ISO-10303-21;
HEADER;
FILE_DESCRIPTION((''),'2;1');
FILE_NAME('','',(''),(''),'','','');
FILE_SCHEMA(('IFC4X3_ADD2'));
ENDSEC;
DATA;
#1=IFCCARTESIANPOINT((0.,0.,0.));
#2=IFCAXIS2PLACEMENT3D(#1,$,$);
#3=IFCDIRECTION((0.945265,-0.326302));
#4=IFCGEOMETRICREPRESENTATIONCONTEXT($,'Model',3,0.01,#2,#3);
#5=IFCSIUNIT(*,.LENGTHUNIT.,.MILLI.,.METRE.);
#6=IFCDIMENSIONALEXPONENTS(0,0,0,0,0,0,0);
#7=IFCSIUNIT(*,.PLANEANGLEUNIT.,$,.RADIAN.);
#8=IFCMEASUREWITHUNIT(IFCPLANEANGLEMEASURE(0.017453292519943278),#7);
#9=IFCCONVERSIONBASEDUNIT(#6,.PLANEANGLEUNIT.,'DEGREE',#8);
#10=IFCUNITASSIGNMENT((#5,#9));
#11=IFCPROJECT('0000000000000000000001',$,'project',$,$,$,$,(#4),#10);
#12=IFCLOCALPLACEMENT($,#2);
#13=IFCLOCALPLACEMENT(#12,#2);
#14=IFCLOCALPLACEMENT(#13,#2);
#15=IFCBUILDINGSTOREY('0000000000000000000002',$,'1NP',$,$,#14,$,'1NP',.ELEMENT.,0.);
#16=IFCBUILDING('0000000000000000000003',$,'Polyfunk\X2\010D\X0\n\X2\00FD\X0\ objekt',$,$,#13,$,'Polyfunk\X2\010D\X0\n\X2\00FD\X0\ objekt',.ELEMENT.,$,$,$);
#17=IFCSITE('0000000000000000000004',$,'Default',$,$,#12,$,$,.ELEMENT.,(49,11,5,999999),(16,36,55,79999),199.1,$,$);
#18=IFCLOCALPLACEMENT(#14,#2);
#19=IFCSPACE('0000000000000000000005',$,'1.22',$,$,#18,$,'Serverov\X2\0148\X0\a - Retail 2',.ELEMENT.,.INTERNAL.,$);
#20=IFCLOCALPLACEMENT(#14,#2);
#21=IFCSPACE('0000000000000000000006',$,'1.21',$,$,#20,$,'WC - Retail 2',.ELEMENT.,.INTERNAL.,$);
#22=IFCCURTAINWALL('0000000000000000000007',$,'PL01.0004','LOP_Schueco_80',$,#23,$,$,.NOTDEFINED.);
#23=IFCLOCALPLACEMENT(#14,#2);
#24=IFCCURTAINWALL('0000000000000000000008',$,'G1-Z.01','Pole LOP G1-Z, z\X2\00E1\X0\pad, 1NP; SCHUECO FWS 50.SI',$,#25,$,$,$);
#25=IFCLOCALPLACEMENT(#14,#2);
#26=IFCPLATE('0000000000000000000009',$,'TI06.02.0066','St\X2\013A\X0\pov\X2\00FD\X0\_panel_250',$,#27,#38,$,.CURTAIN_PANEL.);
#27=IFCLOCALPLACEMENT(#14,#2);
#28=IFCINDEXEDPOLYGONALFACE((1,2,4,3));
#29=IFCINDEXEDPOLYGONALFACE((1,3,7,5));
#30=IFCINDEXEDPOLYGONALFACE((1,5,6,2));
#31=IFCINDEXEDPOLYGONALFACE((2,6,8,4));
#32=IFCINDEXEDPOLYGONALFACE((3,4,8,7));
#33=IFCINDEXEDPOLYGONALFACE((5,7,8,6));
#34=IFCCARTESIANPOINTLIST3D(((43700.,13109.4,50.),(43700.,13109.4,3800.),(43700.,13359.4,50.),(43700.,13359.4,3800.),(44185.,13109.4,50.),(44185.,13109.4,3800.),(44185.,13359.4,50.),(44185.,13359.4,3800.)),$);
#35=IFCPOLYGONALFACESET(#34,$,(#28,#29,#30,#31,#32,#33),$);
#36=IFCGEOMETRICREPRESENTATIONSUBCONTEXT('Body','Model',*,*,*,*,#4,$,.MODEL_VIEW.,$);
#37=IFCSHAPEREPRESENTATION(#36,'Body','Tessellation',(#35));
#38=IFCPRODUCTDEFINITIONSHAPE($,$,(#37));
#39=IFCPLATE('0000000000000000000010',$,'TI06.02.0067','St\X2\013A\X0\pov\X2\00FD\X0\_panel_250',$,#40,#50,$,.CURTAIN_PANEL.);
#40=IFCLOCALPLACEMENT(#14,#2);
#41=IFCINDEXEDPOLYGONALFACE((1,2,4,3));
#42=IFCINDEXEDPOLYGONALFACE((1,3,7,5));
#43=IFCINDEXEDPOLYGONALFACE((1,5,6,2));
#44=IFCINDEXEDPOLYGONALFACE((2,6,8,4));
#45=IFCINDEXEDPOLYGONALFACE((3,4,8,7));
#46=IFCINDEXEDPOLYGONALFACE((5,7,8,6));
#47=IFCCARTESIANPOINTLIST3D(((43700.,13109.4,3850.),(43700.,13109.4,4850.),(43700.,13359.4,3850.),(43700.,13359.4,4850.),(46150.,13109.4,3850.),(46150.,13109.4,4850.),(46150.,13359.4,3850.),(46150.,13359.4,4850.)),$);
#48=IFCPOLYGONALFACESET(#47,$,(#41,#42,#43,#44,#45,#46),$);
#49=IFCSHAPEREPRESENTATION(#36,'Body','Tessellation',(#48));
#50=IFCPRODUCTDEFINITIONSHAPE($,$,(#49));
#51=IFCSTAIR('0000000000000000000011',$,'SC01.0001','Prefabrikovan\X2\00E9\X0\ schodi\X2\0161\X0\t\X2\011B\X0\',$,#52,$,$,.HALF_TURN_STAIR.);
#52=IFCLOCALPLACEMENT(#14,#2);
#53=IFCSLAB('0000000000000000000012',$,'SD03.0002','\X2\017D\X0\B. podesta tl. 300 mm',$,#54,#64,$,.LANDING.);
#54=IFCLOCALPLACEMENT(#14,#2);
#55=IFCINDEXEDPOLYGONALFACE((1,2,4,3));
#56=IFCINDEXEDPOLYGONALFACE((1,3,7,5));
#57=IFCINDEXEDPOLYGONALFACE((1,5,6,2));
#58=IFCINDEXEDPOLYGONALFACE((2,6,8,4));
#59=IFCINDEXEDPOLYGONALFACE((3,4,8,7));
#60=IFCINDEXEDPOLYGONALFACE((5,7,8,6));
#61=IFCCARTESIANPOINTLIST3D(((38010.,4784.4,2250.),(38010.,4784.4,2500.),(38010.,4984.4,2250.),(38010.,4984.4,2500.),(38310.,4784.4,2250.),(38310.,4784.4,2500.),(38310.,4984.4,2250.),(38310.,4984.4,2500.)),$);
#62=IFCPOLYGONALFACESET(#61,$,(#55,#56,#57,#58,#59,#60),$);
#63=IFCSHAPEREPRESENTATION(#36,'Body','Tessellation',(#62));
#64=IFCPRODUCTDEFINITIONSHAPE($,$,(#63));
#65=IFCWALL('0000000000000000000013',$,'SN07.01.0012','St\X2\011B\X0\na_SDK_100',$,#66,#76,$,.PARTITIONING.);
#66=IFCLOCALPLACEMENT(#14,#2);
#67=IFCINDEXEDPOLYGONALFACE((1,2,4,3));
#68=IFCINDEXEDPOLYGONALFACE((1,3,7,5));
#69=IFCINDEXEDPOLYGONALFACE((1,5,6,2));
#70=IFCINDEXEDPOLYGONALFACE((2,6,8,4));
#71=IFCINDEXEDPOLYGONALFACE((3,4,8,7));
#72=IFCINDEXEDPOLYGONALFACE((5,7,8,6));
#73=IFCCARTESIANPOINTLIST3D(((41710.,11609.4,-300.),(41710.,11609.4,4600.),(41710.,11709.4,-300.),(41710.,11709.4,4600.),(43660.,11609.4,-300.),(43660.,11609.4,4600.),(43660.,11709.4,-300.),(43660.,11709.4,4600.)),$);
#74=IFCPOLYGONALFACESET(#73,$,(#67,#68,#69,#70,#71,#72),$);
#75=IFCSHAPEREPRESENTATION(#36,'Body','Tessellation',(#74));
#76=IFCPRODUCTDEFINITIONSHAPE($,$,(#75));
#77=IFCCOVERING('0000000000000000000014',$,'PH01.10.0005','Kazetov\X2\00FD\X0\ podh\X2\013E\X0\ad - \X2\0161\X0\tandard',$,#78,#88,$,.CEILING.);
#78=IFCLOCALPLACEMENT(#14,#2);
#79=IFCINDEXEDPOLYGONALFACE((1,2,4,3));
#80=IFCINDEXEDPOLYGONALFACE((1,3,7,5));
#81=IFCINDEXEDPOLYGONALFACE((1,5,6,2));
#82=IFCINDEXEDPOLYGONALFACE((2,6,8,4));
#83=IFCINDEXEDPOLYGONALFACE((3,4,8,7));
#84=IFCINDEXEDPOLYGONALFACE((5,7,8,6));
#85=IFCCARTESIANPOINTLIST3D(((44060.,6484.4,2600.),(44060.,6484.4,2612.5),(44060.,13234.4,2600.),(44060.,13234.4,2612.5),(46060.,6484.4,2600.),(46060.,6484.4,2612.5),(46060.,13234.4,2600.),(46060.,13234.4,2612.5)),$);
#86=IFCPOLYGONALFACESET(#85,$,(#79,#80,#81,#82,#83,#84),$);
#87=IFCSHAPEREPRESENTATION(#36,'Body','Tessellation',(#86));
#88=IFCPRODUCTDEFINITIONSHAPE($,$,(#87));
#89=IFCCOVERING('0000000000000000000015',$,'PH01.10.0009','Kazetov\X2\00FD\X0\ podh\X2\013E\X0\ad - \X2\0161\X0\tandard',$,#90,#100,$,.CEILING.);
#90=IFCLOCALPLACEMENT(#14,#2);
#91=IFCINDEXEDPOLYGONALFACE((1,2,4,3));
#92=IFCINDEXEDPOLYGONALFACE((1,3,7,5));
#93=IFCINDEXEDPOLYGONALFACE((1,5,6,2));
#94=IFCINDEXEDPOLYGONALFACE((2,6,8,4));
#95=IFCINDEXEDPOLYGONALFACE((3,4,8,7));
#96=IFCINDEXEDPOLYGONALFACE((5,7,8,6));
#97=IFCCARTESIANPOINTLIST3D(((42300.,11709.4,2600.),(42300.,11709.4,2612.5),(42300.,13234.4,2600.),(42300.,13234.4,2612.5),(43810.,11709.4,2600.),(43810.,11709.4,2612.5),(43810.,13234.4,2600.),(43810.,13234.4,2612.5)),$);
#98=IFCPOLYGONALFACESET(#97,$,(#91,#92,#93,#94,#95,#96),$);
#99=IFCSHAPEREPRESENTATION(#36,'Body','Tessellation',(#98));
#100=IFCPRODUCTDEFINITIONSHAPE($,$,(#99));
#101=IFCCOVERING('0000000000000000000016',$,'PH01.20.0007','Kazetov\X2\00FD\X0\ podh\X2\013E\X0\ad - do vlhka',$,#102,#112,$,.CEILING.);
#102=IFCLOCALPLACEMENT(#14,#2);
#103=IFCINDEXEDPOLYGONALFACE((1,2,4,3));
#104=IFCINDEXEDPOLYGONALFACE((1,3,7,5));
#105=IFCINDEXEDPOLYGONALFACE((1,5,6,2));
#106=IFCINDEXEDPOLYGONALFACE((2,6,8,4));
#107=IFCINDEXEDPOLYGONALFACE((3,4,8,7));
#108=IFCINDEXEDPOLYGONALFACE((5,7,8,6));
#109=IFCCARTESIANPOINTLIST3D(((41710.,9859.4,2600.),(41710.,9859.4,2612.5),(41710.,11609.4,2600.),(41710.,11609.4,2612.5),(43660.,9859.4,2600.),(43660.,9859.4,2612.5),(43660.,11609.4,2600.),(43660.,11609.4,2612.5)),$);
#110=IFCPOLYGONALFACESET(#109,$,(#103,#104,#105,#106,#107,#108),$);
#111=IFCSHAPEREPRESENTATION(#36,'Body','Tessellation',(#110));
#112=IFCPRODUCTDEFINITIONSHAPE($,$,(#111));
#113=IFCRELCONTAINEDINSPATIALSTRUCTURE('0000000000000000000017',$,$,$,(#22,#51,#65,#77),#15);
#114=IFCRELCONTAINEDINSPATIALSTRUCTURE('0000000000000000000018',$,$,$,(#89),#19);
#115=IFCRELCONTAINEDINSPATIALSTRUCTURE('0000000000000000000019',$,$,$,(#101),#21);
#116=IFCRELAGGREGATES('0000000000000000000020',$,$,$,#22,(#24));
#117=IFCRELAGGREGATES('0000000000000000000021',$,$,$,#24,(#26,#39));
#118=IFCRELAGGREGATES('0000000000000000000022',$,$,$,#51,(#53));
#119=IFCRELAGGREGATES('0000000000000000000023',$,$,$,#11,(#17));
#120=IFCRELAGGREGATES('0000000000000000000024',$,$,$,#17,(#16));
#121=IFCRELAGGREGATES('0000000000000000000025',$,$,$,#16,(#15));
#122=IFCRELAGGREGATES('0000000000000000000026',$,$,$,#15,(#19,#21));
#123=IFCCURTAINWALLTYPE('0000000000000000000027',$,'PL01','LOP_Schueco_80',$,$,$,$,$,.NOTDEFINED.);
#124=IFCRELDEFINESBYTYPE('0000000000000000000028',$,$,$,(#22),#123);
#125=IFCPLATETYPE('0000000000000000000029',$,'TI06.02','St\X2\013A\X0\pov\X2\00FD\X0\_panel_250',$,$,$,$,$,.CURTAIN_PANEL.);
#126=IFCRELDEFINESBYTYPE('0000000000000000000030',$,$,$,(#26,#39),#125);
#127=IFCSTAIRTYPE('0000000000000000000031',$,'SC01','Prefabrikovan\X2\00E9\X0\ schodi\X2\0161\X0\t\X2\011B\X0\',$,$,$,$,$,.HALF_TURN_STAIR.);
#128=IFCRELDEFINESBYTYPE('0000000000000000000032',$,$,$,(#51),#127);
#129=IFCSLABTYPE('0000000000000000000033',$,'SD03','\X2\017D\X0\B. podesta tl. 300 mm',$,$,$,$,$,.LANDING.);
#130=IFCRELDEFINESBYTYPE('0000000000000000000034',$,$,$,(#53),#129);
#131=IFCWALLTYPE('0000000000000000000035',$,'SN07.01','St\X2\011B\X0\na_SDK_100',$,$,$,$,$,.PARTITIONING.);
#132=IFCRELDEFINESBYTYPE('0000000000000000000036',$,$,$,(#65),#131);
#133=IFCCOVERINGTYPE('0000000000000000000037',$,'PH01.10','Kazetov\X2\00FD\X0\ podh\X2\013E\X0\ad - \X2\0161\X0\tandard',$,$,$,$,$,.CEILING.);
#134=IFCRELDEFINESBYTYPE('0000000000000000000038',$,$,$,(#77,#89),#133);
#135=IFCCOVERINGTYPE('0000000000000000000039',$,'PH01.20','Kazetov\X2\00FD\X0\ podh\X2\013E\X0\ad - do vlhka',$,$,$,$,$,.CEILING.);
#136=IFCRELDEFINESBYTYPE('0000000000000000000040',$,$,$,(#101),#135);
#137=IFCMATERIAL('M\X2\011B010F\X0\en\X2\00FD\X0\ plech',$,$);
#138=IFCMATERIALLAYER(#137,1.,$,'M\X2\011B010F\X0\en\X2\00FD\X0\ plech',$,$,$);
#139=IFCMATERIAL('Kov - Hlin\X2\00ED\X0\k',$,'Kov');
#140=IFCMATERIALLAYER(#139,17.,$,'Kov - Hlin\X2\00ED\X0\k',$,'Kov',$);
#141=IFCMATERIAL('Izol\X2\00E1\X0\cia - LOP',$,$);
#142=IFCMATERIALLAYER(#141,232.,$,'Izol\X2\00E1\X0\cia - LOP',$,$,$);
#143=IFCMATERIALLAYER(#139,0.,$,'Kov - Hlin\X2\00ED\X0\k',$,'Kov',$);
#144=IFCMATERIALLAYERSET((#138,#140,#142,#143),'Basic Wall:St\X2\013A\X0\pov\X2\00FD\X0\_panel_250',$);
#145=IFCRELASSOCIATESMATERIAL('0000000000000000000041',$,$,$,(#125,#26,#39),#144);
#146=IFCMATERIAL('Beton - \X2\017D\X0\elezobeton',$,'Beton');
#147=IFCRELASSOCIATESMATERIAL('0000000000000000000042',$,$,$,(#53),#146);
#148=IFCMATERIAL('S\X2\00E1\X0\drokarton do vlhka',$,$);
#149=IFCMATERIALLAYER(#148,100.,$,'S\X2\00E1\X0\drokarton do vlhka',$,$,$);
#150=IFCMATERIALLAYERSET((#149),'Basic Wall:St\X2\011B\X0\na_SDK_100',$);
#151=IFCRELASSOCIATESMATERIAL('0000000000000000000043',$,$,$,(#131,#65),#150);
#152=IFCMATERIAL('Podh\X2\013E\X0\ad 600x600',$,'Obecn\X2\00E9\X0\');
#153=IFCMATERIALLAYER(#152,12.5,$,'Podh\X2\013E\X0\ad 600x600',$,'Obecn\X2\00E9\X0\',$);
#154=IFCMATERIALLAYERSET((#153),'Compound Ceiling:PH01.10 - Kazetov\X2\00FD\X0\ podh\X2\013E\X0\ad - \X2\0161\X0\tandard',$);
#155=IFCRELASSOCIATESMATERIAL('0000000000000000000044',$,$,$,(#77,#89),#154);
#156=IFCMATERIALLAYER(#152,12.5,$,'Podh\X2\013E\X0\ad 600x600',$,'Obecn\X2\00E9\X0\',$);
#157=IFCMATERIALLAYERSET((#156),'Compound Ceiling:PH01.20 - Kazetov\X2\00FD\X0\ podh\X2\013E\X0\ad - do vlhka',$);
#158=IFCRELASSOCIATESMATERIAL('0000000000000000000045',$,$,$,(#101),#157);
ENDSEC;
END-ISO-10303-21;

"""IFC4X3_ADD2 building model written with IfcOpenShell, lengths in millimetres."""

from ifc_helpers import new_model, entity, si_unit, converted_unit, direction, frame, frame_2d, origin, place, context, subcontext, project, spatial, polyline, rectangle, extrude, clip, bounded_halfspace, material, layer, layer_set, layer_usage, type_object, element, aggregate, save


model = new_model("IFC4X3_ADD2")

# Units and contexts
model_context = context("Model", 3, precision=0.01, world=origin(), true_north=direction((0.945265, -0.326302)))
body_context = subcontext(model_context, "Body", "Model", "MODEL_VIEW")
ifc_project = project(units=[si_unit("LENGTHUNIT", "METRE", prefix="MILLI"), converted_unit("PLANEANGLEUNIT", "DEGREE", entity("IfcPlaneAngleMeasure", 0.017453292519943278), si_unit("PLANEANGLEUNIT", "RADIAN"), dimensions=[0, 0, 0, 0, 0, 0, 0])], contexts=[model_context])

# Site, building, storey
site_placement = place(None, origin())
site = spatial("IfcSite", under=ifc_project, at=site_placement, Name="Default", CompositionType="ELEMENT", RefLatitude=(49, 11, 5, 999999), RefLongitude=(16, 36, 55, 79999), RefElevation=199.1)
building_placement = place(site_placement, origin())
building = spatial("IfcBuilding", under=site, at=building_placement, Name="Polyfunkčný objekt", LongName="Polyfunkčný objekt", CompositionType="ELEMENT")
storey_placement = place(building_placement, origin())
storey = spatial("IfcBuildingStorey", under=building, at=storey_placement, Name="1NP", LongName="1NP", CompositionType="ELEMENT", Elevation=0.0)

# Curtain walls, plates
curtain_wall_type = type_object("IfcCurtainWallType", Name="PL01", Description="LOP_Schueco_80", PredefinedType="NOTDEFINED")
curtain_wall_1_placement = place(storey_placement, origin())
curtain_wall_1 = element("IfcCurtainWall", 1, at=curtain_wall_1_placement, inside=storey, type_object=curtain_wall_type, Name="PL01.0004", Description="LOP_Schueco_80", PredefinedType="NOTDEFINED")
curtain_wall_2 = element("IfcCurtainWall", 2, Name="G1-Z.01", Description="Pole LOP G1-Z, západ, 1NP; SCHUECO FWS 50.SI")
aggregate(curtain_wall_1, [curtain_wall_2])
ifc_material_1 = material(Name="Měďený plech")
ifc_layer_1 = layer(ifc_material_1, 1.0, Name="Měďený plech")
ifc_material_2 = material(Name="Kov - Hliník", Category="Kov")
ifc_layer_2 = layer(ifc_material_2, 17.0, Name="Kov - Hliník", Category="Kov")
ifc_material_3 = material(Name="Izolácia - LOP")
ifc_layer_3 = layer(ifc_material_3, 232.0, Name="Izolácia - LOP")
ifc_layer_4 = layer(ifc_material_2, 0.0, Name="Kov - Hliník", Category="Kov")
ifc_layer_set_1 = layer_set([ifc_layer_1, ifc_layer_2, ifc_layer_3, ifc_layer_4], Name="Basic Wall:Stĺpový_panel_250")
ifc_layer_usage_1 = layer_usage(ifc_layer_set_1, "AXIS2", "NEGATIVE", 125.0)
plate_type = type_object("IfcPlateType", Name="TI06.02", Description="Stĺpový_panel_250", PredefinedType="CURTAIN_PANEL", material=ifc_layer_set_1)
plate_1_placement = place(storey_placement, frame((43700.0, 13234.4, 50.0)))
plate_1 = element("IfcPlate", 3, at=plate_1_placement, type_object=plate_type, material=ifc_layer_usage_1, Name="TI06.02.0066", Description="Stĺpový_panel_250", PredefinedType="CURTAIN_PANEL", context=body_context, shape_type="SweptSolid", body=[
    extrude(rectangle(XDim=250.0, YDim=485.0, at=frame_2d((0.0, 0.0), x_axis=(1.0, 0.0))), frame((242.5, 0.0, 0.0), z_axis=(0.0, 0.0, 1.0), x_axis=(0.0, 1.0, 0.0)), (0.0, 0.0, 1.0), 3750.0),
])
ifc_layer_usage_2 = layer_usage(ifc_layer_set_1, "AXIS2", "NEGATIVE", 125.0)
plate_2_placement = place(storey_placement, frame((43700.0, 13234.4, 3850.0)))
plate_2 = element("IfcPlate", 4, at=plate_2_placement, type_object=plate_type, material=ifc_layer_usage_2, Name="TI06.02.0067", Description="Stĺpový_panel_250", PredefinedType="CURTAIN_PANEL", context=body_context, shape_type="SweptSolid", body=[
    extrude(rectangle(XDim=250.0, YDim=2450.0, at=frame_2d((0.0, 0.0), x_axis=(1.0, 0.0))), frame((1225.0, 0.0, 0.0), z_axis=(0.0, 0.0, 1.0), x_axis=(0.0, 1.0, 0.0)), (0.0, 0.0, 1.0), 1000.0),
])
aggregate(curtain_wall_2, [plate_1, plate_2])

# Stair, slab
stair_type = type_object("IfcStairType", Name="SC01", Description="Prefabrikované schodiště", PredefinedType="HALF_TURN_STAIR")
stair_placement = place(storey_placement, origin())
stair = element("IfcStair", 5, at=stair_placement, inside=storey, type_object=stair_type, Name="SC01.0001", Description="Prefabrikované schodiště", PredefinedType="HALF_TURN_STAIR")
ifc_material_4 = material(Name="Beton - Železobeton", Category="Beton")
slab_type = type_object("IfcSlabType", Name="SD03", Description="ŽB. podesta tl. 300 mm", PredefinedType="LANDING")
slab_placement = place(stair_placement, frame((38010.0, 4784.4, 0.0)))
slab = element("IfcSlab", 6, at=slab_placement, type_object=slab_type, material=ifc_material_4, Name="SD03.0002", Description="ŽB. podesta tl. 300 mm", PredefinedType="LANDING", context=body_context, shape_type="SweptSolid", body=[
    extrude(rectangle(XDim=200.0, YDim=300.0, at=frame_2d((0.0, 0.0), x_axis=(1.0, 0.0))), frame((150.0, 100.0, 2250.0), z_axis=(0.0, 0.0, 1.0), x_axis=(0.0, 1.0, 0.0)), (0.0, 0.0, 1.0), 250.0),
])
aggregate(stair, [slab])

# Wall
ifc_material_5 = material(Name="Sádrokarton do vlhka")
ifc_layer_5 = layer(ifc_material_5, 100.0, Name="Sádrokarton do vlhka")
ifc_layer_set_2 = layer_set([ifc_layer_5], Name="Basic Wall:Stěna_SDK_100")
wall_type_1 = type_object("IfcWallType", Name="SN07.01", Description="Stěna_SDK_100", PredefinedType="PARTITIONING", material=ifc_layer_set_2)
wall_1_placement = place(storey_placement, frame((41710.0, 11659.4, -300.0)))
element("IfcWall", 7, at=wall_1_placement, inside=storey, type_object=wall_type_1, material=ifc_layer_set_2, Name="SN07.01.0012", Description="Stěna_SDK_100", PredefinedType="PARTITIONING", context=body_context, shape_type="Clipping", body=[
    clip(clip(extrude(rectangle(XDim=1950.0, YDim=100.0, at=frame_2d((975.0, 0.0), x_axis=(-1.0, 0.0))), origin(), (0.0, 0.0, 1.0), 4900.0), bounded_halfspace(frame((0.0, -50.0, 4900.0), z_axis=(0.0, 0.0, -1.0), x_axis=(1.0, 0.0, 0.0)), True, frame((0.0, -50.0, 4900.0)), polyline([(0.0, 0.0), (900.0, 0.0), (1050.0, 0.0), (1950.0, 0.0), (1950.0, 100.0), (0.0, 100.0), (0.0, 0.0)]))), bounded_halfspace(frame((1950.0, -50.0, 0.0), z_axis=(0.0, 0.0, 1.0), x_axis=(0.0, 1.0, 0.0)), True, frame((1950.0, -50.0, 0.0)), polyline([(0.0, 0.0), (0.0, 100.0), (-1950.0, 100.0), (-1950.0, 0.0), (-1050.0, 0.0), (-900.0, 0.0), (0.0, 0.0)]))),
])

# Covering
ifc_material_6 = material(Name="Podhľad 600x600", Category="Obecné")
ifc_layer_6 = layer(ifc_material_6, 12.5, Name="Podhľad 600x600", Category="Obecné")
ifc_layer_set_3 = layer_set([ifc_layer_6], Name="Compound Ceiling:PH01.10 - Kazetový podhľad - štandard")
ifc_layer_usage_3 = layer_usage(ifc_layer_set_3, "AXIS3", "NEGATIVE", 0.0)
covering_type_1 = type_object("IfcCoveringType", Name="PH01.10", Description="Kazetový podhľad - štandard", PredefinedType="CEILING")
covering_1_placement = place(storey_placement, frame((44060.0, 6484.4, 2600.0)))
element("IfcCovering", 8, at=covering_1_placement, inside=storey, type_object=covering_type_1, material=ifc_layer_usage_3, Name="PH01.10.0005", Description="Kazetový podhľad - štandard", PredefinedType="CEILING", context=body_context, shape_type="SweptSolid", body=[
    extrude(rectangle(XDim=2000.0, YDim=6750.0, at=frame_2d((0.0, 0.0), x_axis=(1.0, 0.0))), frame((1000.0, 3375.0, 0.0), z_axis=(0.0, 0.0, 1.0), x_axis=(-1.0, 0.0, 0.0)), (0.0, 0.0, 1.0), 12.5),
])

# Shared definitions
space_1_placement = place(storey_placement, origin())
space_1 = spatial("IfcSpace", under=storey, at=space_1_placement, Name="1.22", LongName="Serverovňa - Retail 2", CompositionType="ELEMENT", PredefinedType="INTERNAL")

# Covering
ifc_layer_usage_4 = layer_usage(ifc_layer_set_3, "AXIS3", "NEGATIVE", 0.0)
covering_2_placement = place(storey_placement, frame((42300.0, 11709.4, 2600.0)))
element("IfcCovering", 9, at=covering_2_placement, inside=space_1, type_object=covering_type_1, material=ifc_layer_usage_4, Name="PH01.10.0009", Description="Kazetový podhľad - štandard", PredefinedType="CEILING", context=body_context, shape_type="SweptSolid", body=[
    extrude(rectangle(XDim=1510.0, YDim=1525.0, at=frame_2d((0.0, 0.0), x_axis=(1.0, 0.0))), frame((755.0, 762.5, 0.0), z_axis=(0.0, 0.0, 1.0), x_axis=(-1.0, 0.0, 0.0)), (0.0, 0.0, 1.0), 12.5),
])

# Shared definitions
space_2_placement = place(storey_placement, origin())
space_2 = spatial("IfcSpace", under=storey, at=space_2_placement, Name="1.21", LongName="WC - Retail 2", CompositionType="ELEMENT", PredefinedType="INTERNAL")

# Covering
ifc_layer_7 = layer(ifc_material_6, 12.5, Name="Podhľad 600x600", Category="Obecné")
ifc_layer_set_4 = layer_set([ifc_layer_7], Name="Compound Ceiling:PH01.20 - Kazetový podhľad - do vlhka")
ifc_layer_usage_5 = layer_usage(ifc_layer_set_4, "AXIS3", "NEGATIVE", 0.0)
covering_type_2 = type_object("IfcCoveringType", Name="PH01.20", Description="Kazetový podhľad - do vlhka", PredefinedType="CEILING")
covering_3_placement = place(storey_placement, frame((41710.0, 9859.4, 2600.0)))
element("IfcCovering", 10, at=covering_3_placement, inside=space_2, type_object=covering_type_2, material=ifc_layer_usage_5, Name="PH01.20.0007", Description="Kazetový podhľad - do vlhka", PredefinedType="CEILING", context=body_context, shape_type="SweptSolid", body=[
    extrude(rectangle(XDim=1950.0, YDim=1750.0, at=frame_2d((0.0, 0.0), x_axis=(1.0, 0.0))), frame((975.0, 875.0, 0.0), z_axis=(0.0, 0.0, 1.0), x_axis=(-1.0, 0.0, 0.0)), (0.0, 0.0, 1.0), 12.5),
])

save(model, "model.ifc")
